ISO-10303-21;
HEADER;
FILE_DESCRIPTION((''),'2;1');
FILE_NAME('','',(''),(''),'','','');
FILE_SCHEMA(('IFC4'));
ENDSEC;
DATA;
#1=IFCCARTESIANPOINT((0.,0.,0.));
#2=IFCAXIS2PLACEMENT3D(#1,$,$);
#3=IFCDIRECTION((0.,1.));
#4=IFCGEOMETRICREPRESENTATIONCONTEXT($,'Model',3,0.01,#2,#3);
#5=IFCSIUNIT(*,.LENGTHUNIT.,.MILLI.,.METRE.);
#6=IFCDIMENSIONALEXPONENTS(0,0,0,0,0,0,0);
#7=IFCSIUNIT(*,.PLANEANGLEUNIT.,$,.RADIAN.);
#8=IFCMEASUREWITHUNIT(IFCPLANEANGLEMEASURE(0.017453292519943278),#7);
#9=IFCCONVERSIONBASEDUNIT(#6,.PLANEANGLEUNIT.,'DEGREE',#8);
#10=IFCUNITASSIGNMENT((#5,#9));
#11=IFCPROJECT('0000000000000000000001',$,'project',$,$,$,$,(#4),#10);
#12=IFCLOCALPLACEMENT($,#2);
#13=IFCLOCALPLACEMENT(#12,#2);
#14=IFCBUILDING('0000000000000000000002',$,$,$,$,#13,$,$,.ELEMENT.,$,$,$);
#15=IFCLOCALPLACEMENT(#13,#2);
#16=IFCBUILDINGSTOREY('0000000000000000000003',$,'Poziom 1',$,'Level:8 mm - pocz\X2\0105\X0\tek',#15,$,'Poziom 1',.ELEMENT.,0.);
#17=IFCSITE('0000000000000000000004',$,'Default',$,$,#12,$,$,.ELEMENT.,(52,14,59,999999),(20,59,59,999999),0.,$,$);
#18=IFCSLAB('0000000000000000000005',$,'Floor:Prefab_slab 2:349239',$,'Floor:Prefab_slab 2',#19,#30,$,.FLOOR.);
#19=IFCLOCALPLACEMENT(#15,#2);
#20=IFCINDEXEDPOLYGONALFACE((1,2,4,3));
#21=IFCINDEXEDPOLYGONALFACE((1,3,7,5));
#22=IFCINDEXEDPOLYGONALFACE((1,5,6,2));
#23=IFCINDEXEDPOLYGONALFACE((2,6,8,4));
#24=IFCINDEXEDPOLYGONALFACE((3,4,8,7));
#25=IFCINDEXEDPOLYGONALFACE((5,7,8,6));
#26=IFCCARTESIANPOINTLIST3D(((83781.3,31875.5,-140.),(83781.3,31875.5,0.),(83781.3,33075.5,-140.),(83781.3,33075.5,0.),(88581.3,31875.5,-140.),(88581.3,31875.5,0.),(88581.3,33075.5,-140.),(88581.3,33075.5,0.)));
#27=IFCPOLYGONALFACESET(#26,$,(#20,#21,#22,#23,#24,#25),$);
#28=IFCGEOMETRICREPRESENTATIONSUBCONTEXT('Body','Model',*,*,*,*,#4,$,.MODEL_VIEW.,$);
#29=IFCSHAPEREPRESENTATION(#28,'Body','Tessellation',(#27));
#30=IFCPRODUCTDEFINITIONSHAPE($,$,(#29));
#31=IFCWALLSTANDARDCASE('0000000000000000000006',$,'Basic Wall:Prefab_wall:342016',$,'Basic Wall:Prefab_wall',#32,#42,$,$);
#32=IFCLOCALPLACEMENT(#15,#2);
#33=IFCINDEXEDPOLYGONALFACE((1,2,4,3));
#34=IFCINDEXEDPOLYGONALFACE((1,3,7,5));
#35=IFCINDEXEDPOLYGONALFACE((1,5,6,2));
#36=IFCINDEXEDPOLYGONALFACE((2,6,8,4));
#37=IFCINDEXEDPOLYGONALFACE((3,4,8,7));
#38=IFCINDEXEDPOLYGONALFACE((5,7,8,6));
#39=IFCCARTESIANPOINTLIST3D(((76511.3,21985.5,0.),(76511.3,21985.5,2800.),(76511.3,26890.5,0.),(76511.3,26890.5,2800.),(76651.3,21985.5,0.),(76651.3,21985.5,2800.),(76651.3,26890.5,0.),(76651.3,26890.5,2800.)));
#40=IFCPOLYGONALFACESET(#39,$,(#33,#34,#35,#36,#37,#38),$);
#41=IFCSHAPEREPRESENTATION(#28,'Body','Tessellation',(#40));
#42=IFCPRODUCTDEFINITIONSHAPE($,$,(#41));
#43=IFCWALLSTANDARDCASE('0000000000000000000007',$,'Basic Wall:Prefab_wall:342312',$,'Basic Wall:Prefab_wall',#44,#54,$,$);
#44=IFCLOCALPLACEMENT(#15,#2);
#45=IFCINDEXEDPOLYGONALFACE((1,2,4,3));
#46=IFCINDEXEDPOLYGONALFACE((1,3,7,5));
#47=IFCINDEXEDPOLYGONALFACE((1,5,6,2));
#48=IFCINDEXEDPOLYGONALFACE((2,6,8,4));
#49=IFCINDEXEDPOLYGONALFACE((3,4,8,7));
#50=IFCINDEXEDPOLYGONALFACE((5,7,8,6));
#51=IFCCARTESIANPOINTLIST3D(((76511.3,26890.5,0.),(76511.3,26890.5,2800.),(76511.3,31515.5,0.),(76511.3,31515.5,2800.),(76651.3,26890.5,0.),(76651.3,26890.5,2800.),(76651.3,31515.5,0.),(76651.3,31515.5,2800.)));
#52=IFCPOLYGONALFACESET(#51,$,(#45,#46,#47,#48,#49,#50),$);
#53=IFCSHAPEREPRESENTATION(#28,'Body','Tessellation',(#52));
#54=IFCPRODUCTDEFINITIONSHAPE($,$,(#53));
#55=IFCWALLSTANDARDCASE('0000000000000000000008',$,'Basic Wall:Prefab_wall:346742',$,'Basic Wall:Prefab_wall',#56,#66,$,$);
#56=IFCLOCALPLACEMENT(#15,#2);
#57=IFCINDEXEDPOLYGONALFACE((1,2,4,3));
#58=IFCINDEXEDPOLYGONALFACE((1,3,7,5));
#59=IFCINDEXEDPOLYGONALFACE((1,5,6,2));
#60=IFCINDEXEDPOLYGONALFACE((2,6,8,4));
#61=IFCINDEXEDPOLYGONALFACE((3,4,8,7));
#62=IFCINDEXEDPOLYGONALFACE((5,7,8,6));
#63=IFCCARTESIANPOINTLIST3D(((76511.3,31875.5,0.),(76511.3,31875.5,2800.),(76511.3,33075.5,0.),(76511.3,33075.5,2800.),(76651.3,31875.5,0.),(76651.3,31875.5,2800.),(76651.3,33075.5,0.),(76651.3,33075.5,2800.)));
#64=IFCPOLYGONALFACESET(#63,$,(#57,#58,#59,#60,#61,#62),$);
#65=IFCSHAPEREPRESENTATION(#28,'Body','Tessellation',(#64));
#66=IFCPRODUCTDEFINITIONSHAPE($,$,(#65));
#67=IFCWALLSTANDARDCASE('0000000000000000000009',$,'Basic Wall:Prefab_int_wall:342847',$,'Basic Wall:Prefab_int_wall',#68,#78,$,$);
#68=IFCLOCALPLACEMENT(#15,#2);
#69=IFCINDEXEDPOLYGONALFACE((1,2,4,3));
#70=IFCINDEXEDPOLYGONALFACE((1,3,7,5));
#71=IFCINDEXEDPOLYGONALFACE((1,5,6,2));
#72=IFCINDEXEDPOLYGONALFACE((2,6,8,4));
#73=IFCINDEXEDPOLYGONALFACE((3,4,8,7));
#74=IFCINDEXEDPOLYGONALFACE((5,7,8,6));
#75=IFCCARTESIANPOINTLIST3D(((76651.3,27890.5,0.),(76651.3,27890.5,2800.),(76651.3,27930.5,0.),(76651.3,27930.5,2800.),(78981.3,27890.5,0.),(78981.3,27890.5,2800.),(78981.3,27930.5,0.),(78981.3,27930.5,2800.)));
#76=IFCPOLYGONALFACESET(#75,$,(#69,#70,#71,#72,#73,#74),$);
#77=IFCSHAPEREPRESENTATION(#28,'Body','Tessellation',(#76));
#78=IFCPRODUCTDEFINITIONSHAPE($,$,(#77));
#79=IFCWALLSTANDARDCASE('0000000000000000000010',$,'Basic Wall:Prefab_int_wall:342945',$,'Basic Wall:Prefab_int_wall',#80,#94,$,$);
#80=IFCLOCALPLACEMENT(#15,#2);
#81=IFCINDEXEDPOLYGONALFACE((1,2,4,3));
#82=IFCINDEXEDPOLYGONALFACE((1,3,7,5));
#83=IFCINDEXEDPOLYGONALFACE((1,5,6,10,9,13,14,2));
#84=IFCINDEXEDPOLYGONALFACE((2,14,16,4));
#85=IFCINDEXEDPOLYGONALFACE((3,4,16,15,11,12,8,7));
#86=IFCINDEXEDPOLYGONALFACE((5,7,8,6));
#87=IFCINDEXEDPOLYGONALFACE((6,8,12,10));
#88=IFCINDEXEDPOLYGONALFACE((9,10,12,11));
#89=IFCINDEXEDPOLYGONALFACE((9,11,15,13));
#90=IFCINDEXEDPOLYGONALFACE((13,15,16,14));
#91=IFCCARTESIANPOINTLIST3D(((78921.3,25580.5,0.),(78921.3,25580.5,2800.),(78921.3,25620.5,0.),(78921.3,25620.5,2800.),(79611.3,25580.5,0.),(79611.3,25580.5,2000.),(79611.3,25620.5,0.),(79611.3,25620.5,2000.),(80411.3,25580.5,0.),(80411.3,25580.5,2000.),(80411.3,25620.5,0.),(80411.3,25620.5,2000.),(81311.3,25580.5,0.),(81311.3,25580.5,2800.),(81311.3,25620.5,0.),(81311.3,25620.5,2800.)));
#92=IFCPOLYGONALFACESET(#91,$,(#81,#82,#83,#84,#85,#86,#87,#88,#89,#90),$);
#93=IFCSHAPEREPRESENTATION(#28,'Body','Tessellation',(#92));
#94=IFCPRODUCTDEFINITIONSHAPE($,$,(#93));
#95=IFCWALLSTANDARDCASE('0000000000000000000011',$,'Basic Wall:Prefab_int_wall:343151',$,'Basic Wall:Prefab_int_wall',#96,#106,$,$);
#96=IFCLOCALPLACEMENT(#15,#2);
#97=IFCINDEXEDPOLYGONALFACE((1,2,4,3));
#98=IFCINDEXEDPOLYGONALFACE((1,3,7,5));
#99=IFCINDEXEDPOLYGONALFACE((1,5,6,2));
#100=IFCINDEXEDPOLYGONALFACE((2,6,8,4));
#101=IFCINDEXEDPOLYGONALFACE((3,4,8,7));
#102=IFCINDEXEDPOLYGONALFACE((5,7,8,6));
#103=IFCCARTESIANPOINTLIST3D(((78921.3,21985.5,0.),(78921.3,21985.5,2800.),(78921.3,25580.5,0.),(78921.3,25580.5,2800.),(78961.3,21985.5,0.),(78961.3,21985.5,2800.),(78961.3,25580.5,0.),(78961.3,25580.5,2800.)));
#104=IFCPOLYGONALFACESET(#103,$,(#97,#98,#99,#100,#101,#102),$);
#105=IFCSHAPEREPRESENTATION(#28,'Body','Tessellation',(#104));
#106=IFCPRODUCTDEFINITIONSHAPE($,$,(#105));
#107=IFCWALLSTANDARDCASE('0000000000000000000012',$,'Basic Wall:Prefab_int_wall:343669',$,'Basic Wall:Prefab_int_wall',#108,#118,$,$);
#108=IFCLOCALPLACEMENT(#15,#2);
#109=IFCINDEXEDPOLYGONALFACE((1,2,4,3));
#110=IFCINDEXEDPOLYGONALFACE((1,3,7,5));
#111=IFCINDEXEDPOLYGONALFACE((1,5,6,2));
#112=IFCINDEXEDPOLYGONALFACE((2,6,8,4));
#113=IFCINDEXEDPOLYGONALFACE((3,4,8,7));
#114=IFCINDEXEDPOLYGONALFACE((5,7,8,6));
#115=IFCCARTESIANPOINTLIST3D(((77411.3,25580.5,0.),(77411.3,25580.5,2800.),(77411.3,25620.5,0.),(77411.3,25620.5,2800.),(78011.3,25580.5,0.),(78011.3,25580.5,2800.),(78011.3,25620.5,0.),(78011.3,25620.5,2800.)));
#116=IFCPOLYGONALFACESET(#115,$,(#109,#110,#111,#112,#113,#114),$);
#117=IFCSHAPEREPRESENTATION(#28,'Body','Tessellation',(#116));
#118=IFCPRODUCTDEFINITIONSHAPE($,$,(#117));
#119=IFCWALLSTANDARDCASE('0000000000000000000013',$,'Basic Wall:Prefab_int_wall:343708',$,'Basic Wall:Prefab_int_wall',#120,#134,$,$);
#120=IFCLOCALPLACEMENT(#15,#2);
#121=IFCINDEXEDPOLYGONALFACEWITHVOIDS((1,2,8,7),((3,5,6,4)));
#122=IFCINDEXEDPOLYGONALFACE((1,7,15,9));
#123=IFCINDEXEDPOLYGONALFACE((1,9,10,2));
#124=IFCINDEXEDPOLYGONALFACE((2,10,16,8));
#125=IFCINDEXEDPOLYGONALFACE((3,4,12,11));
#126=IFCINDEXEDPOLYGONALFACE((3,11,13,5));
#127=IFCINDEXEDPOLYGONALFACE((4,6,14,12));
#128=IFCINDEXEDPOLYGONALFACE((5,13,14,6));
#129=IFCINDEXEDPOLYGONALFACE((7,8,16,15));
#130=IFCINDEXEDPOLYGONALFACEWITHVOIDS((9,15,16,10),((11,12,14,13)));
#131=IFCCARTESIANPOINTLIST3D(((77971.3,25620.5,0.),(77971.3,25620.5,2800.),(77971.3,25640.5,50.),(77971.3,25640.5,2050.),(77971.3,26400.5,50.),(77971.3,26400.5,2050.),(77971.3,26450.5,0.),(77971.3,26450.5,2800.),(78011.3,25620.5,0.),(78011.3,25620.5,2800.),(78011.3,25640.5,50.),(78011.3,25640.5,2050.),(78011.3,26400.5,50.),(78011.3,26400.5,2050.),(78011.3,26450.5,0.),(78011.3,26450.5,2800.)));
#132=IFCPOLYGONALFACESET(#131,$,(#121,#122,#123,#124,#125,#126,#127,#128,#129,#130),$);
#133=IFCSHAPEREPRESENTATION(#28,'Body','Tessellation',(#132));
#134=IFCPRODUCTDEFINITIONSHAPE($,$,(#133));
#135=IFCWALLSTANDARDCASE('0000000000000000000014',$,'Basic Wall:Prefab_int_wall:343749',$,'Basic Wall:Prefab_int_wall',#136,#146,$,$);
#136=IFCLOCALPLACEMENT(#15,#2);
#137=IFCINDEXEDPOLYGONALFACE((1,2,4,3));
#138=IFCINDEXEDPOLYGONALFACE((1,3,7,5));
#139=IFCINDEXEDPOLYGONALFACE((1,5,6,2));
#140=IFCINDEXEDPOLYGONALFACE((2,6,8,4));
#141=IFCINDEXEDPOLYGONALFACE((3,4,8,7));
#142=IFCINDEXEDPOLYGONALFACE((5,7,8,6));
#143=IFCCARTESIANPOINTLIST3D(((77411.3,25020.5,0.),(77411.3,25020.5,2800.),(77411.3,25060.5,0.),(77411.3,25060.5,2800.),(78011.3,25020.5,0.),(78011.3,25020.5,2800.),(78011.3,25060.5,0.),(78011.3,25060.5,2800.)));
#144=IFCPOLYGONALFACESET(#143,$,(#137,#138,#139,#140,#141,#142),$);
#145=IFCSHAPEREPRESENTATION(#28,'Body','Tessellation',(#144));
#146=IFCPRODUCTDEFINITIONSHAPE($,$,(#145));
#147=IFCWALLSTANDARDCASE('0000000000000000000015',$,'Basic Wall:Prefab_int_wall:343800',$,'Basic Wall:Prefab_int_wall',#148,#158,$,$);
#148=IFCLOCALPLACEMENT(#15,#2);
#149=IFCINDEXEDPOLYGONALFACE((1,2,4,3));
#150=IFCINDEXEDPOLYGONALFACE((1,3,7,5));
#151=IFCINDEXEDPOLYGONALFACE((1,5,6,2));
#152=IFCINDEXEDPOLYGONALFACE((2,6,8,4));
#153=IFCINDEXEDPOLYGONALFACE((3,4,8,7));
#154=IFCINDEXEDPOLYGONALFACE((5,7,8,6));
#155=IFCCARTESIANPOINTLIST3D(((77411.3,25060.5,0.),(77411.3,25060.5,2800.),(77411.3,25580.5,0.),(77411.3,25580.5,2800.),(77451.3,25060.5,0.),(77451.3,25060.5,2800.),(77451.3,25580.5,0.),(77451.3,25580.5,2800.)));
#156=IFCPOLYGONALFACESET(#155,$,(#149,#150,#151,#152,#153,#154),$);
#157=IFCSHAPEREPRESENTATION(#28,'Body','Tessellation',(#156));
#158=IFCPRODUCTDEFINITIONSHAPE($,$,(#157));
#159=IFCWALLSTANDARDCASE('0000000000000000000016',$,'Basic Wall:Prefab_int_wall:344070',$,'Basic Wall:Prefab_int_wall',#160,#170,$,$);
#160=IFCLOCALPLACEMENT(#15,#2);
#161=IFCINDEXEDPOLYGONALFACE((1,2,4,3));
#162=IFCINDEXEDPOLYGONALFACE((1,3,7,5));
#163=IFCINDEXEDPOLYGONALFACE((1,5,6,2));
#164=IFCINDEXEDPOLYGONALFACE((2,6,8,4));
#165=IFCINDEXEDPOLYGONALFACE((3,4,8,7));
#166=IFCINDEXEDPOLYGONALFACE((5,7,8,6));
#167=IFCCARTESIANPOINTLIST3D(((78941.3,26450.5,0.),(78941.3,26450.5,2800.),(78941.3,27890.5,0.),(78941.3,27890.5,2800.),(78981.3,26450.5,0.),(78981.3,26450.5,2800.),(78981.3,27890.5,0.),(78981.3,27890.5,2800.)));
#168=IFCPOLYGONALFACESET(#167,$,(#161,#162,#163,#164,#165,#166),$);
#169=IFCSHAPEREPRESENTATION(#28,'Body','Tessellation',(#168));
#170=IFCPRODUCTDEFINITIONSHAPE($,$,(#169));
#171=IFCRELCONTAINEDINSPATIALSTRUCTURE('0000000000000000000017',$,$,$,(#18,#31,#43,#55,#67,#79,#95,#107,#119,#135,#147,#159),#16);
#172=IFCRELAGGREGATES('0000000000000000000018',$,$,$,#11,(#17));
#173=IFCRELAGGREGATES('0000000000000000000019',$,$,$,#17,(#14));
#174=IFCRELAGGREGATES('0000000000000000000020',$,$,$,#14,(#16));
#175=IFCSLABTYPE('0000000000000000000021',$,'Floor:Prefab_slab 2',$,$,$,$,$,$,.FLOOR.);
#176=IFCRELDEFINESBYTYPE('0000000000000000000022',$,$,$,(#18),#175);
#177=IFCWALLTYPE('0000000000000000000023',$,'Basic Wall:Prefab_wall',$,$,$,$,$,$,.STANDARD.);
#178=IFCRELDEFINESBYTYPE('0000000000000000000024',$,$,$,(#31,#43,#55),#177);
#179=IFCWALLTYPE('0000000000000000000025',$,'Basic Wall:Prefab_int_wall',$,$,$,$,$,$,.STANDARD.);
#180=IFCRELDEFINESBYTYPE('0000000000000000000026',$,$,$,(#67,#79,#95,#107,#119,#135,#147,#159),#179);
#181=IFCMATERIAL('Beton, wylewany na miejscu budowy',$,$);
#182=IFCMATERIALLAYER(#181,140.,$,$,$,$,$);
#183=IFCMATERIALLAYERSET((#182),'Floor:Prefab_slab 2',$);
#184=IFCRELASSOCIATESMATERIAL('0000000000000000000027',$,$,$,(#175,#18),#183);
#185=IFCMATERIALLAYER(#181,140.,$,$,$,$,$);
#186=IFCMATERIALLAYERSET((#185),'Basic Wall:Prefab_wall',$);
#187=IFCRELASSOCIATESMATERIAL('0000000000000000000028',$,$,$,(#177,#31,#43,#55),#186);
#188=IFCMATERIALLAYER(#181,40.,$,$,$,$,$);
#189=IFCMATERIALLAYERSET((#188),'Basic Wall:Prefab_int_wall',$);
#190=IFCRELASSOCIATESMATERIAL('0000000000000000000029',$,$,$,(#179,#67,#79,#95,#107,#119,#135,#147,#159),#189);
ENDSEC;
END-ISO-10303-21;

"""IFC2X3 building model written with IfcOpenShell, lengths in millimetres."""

from ifc_helpers import new_model, entity, si_unit, converted_unit, direction, frame, frame_2d, origin, origin_2d_with_axis, place, context, subcontext, project, spatial, rectangle, extrude, material, layer, layer_set, layer_usage, type_object, element, save


model = new_model("IFC2X3")

# Units and contexts
model_context = context("Model", 3, precision=0.01, world=origin(), true_north=direction((0.0, 1.0)))
body_context = subcontext(model_context, "Body", "Model", "MODEL_VIEW")
ifc_project = project(units=[si_unit("LENGTHUNIT", "METRE", prefix="MILLI"), converted_unit("PLANEANGLEUNIT", "DEGREE", entity("IfcPlaneAngleMeasure", 0.017453292519943278), si_unit("PLANEANGLEUNIT", "RADIAN"), dimensions=[0, 0, 0, 0, 0, 0, 0])], contexts=[model_context])

# Site, building, storey
site_placement = place(None, origin())
site = spatial("IfcSite", under=ifc_project, at=site_placement, Name="Default", CompositionType="ELEMENT", RefLatitude=(52, 14, 59, 999999), RefLongitude=(20, 59, 59, 999999), RefElevation=0.0)
building_placement = place(site_placement, origin())
building = spatial("IfcBuilding", under=site, at=building_placement, CompositionType="ELEMENT")
storey_placement = place(building_placement, origin())
storey = spatial("IfcBuildingStorey", under=building, at=storey_placement, Name="Poziom 1", ObjectType="Level:8 mm - początek", LongName="Poziom 1", CompositionType="ELEMENT", Elevation=0.0)

# Slab
ifc_material_1 = material(Name="Beton, wylewany na miejscu budowy")
ifc_layer_1 = layer(ifc_material_1, 140.0)
ifc_layer_set_1 = layer_set([ifc_layer_1], Name="Floor:Prefab_slab 2")
slab_type_1 = type_object("IfcSlabType", Name="Floor:Prefab_slab 2", PredefinedType="FLOOR", material=ifc_layer_set_1)
ifc_layer_usage_1 = layer_usage(ifc_layer_set_1, "AXIS3", "POSITIVE", 0.0)
slab_1_placement = place(storey_placement, origin())
element("IfcSlab", 1, at=slab_1_placement, inside=storey, type_object=slab_type_1, material=ifc_layer_usage_1, Name="Floor:Prefab_slab 2:349239", ObjectType="Floor:Prefab_slab 2", PredefinedType="FLOOR", context=body_context, shape_type="SweptSolid", body=[
    extrude(rectangle(XDim=1200.0, YDim=4800.0, at=frame_2d((0.0, 0.0), x_axis=(1.0, 0.0))), frame((86181.3, 32475.5, 0.0), z_axis=(0.0, 0.0, -1.0), x_axis=(0.0, 1.0, 0.0)), (0.0, 0.0, 1.0), 140.0),
])

# Walls
ifc_layer_2 = layer(ifc_material_1, 140.0)
ifc_layer_set_2 = layer_set([ifc_layer_2], Name="Basic Wall:Prefab_wall")
ifc_layer_usage_2 = layer_usage(ifc_layer_set_2, "AXIS2", "NEGATIVE", 70.0)
wall_type_1 = type_object("IfcWallType", Name="Basic Wall:Prefab_wall", PredefinedType="STANDARD", material=ifc_layer_set_2)
wall_1_placement = place(storey_placement, frame((76581.3, 21985.5, 0.0), z_axis=(0.0, 0.0, 1.0), x_axis=(0.0, 1.0, 0.0)))
element("IfcWallStandardCase", 2, at=wall_1_placement, inside=storey, type_object=wall_type_1, material=ifc_layer_usage_2, Name="Basic Wall:Prefab_wall:342016", ObjectType="Basic Wall:Prefab_wall", context=body_context, shape_type="SweptSolid", body=[
    extrude(rectangle(XDim=4905.0, YDim=140.0, at=frame_2d((2452.5, 0.0), x_axis=(-1.0, 0.0))), origin(), (0.0, 0.0, 1.0), 2800.0),
])
ifc_layer_usage_3 = layer_usage(ifc_layer_set_2, "AXIS2", "NEGATIVE", 70.0)
wall_2_placement = place(storey_placement, frame((76581.3, 31515.5, 0.0), z_axis=(0.0, 0.0, 1.0), x_axis=(0.0, -1.0, 0.0)))
element("IfcWallStandardCase", 3, at=wall_2_placement, inside=storey, type_object=wall_type_1, material=ifc_layer_usage_3, Name="Basic Wall:Prefab_wall:342312", ObjectType="Basic Wall:Prefab_wall", context=body_context, shape_type="SweptSolid", body=[
    extrude(rectangle(XDim=4625.0, YDim=140.0, at=frame_2d((2312.5, 0.0), x_axis=(-1.0, 0.0))), origin(), (0.0, 0.0, 1.0), 2800.0),
])
ifc_layer_usage_4 = layer_usage(ifc_layer_set_2, "AXIS2", "NEGATIVE", 70.0)
wall_3_placement = place(storey_placement, frame((76581.3, 33075.5, 0.0), z_axis=(0.0, 0.0, 1.0), x_axis=(0.0, -1.0, 0.0)))
element("IfcWallStandardCase", 4, at=wall_3_placement, inside=storey, type_object=wall_type_1, material=ifc_layer_usage_4, Name="Basic Wall:Prefab_wall:346742", ObjectType="Basic Wall:Prefab_wall", context=body_context, shape_type="SweptSolid", body=[
    extrude(rectangle(XDim=1200.0, YDim=140.0, at=frame_2d((600.0, 0.0), x_axis=(-1.0, 0.0))), origin(), (0.0, 0.0, 1.0), 2800.0),
])
ifc_layer_3 = layer(ifc_material_1, 40.0)
ifc_layer_set_3 = layer_set([ifc_layer_3], Name="Basic Wall:Prefab_int_wall")
ifc_layer_usage_5 = layer_usage(ifc_layer_set_3, "AXIS2", "NEGATIVE", 20.0)
wall_type_2 = type_object("IfcWallType", Name="Basic Wall:Prefab_int_wall", PredefinedType="STANDARD", material=ifc_layer_set_3)
wall_4_placement = place(storey_placement, frame((76651.3, 27910.5, 0.0)))
element("IfcWallStandardCase", 5, at=wall_4_placement, inside=storey, type_object=wall_type_2, material=ifc_layer_usage_5, Name="Basic Wall:Prefab_int_wall:342847", ObjectType="Basic Wall:Prefab_int_wall", context=body_context, shape_type="SweptSolid", body=[
    extrude(rectangle(XDim=2330.0, YDim=40.0, at=frame_2d((1165.0, 0.0), x_axis=(-1.0, 0.0))), origin(), (0.0, 0.0, 1.0), 2800.0),
])

# Wall, opening
ifc_layer_usage_6 = layer_usage(ifc_layer_set_3, "AXIS2", "NEGATIVE", 20.0)
wall_5_placement = place(storey_placement, frame((78921.3, 25600.5, 0.0)))
wall_5 = element("IfcWallStandardCase", 6, at=wall_5_placement, inside=storey, type_object=wall_type_2, material=ifc_layer_usage_6, Name="Basic Wall:Prefab_int_wall:342945", ObjectType="Basic Wall:Prefab_int_wall", context=body_context, shape_type="SweptSolid", body=[
    extrude(rectangle(XDim=2390.0, YDim=40.0, at=frame_2d((1195.0, 0.0), x_axis=(-1.0, 0.0))), origin(), (0.0, 0.0, 1.0), 2800.0),
])
opening_1_placement = place(wall_5_placement, origin())
element("IfcOpeningElement", 7, at=opening_1_placement, cuts=wall_5, ObjectType="Opening", context=body_context, shape_type="SweptSolid", body=[
    extrude(rectangle(XDim=2000.0, YDim=800.0, at=frame_2d((0.0, 0.0), x_axis=(0.0, 1.0))), frame((1090.0, 20.0, 1000.0), z_axis=(0.0, -1.0, 0.0), x_axis=(1.0, 0.0, 0.0)), (0.0, 0.0, 1.0), 40.0),
])

# Walls
ifc_layer_usage_7 = layer_usage(ifc_layer_set_3, "AXIS2", "NEGATIVE", 20.0)
wall_6_placement = place(storey_placement, frame((78941.3, 25580.5, 0.0), z_axis=(0.0, 0.0, 1.0), x_axis=(0.0, -1.0, 0.0)))
element("IfcWallStandardCase", 8, at=wall_6_placement, inside=storey, type_object=wall_type_2, material=ifc_layer_usage_7, Name="Basic Wall:Prefab_int_wall:343151", ObjectType="Basic Wall:Prefab_int_wall", context=body_context, shape_type="SweptSolid", body=[
    extrude(rectangle(XDim=3595.0, YDim=40.0, at=frame_2d((1797.5, 0.0), x_axis=(-1.0, 0.0))), origin(), (0.0, 0.0, 1.0), 2800.0),
])
ifc_layer_usage_8 = layer_usage(ifc_layer_set_3, "AXIS2", "NEGATIVE", 20.0)
wall_7_placement = place(storey_placement, frame((77411.3, 25600.5, 0.0)))
element("IfcWallStandardCase", 9, at=wall_7_placement, inside=storey, type_object=wall_type_2, material=ifc_layer_usage_8, Name="Basic Wall:Prefab_int_wall:343669", ObjectType="Basic Wall:Prefab_int_wall", context=body_context, shape_type="SweptSolid", body=[
    extrude(rectangle(XDim=600.0, YDim=40.0, at=frame_2d((300.0, 0.0), x_axis=(-1.0, 0.0))), origin(), (0.0, 0.0, 1.0), 2800.0),
])

# Wall, opening
ifc_layer_usage_9 = layer_usage(ifc_layer_set_3, "AXIS2", "NEGATIVE", 20.0)
wall_8_placement = place(storey_placement, frame((77991.3, 26450.5, 0.0), z_axis=(0.0, 0.0, 1.0), x_axis=(0.0, -1.0, 0.0)))
wall_8 = element("IfcWallStandardCase", 10, at=wall_8_placement, inside=storey, type_object=wall_type_2, material=ifc_layer_usage_9, Name="Basic Wall:Prefab_int_wall:343708", ObjectType="Basic Wall:Prefab_int_wall", context=body_context, shape_type="SweptSolid", body=[
    extrude(rectangle(XDim=830.0, YDim=40.0, at=frame_2d((415.0, 0.0), x_axis=(-1.0, 0.0))), origin(), (0.0, 0.0, 1.0), 2800.0),
])
opening_2_placement = place(wall_8_placement, origin())
element("IfcOpeningElement", 11, at=opening_2_placement, cuts=wall_8, ObjectType="Opening", context=body_context, shape_type="SweptSolid", body=[
    extrude(rectangle(XDim=2000.0, YDim=760.0, at=origin_2d_with_axis()), frame((430.0, 20.0, 1050.0), z_axis=(0.0, -1.0, 0.0), x_axis=(0.0, 0.0, 1.0)), (0.0, 0.0, 1.0), 40.0),
])

# Walls
ifc_layer_usage_10 = layer_usage(ifc_layer_set_3, "AXIS2", "NEGATIVE", 20.0)
wall_9_placement = place(storey_placement, frame((78011.3, 25040.5, 0.0), z_axis=(0.0, 0.0, 1.0), x_axis=(-1.0, 0.0, 0.0)))
element("IfcWallStandardCase", 12, at=wall_9_placement, inside=storey, type_object=wall_type_2, material=ifc_layer_usage_10, Name="Basic Wall:Prefab_int_wall:343749", ObjectType="Basic Wall:Prefab_int_wall", context=body_context, shape_type="SweptSolid", body=[
    extrude(rectangle(XDim=600.0, YDim=40.0, at=frame_2d((300.0, 0.0), x_axis=(-1.0, 0.0))), origin(), (0.0, 0.0, 1.0), 2800.0),
])
ifc_layer_usage_11 = layer_usage(ifc_layer_set_3, "AXIS2", "NEGATIVE", 20.0)
wall_10_placement = place(storey_placement, frame((77431.3, 25060.5, 0.0), z_axis=(0.0, 0.0, 1.0), x_axis=(0.0, 1.0, 0.0)))
element("IfcWallStandardCase", 13, at=wall_10_placement, inside=storey, type_object=wall_type_2, material=ifc_layer_usage_11, Name="Basic Wall:Prefab_int_wall:343800", ObjectType="Basic Wall:Prefab_int_wall", context=body_context, shape_type="SweptSolid", body=[
    extrude(rectangle(XDim=520.0, YDim=40.0, at=frame_2d((260.0, 0.0), x_axis=(-1.0, 0.0))), origin(), (0.0, 0.0, 1.0), 2800.0),
])
ifc_layer_usage_12 = layer_usage(ifc_layer_set_3, "AXIS2", "NEGATIVE", 20.0)
wall_11_placement = place(storey_placement, frame((78961.3, 27890.5, 0.0), z_axis=(0.0, 0.0, 1.0), x_axis=(0.0, -1.0, 0.0)))
element("IfcWallStandardCase", 14, at=wall_11_placement, inside=storey, type_object=wall_type_2, material=ifc_layer_usage_12, Name="Basic Wall:Prefab_int_wall:344070", ObjectType="Basic Wall:Prefab_int_wall", context=body_context, shape_type="SweptSolid", body=[
    extrude(rectangle(XDim=1440.0, YDim=40.0, at=frame_2d((720.0, 0.0), x_axis=(-1.0, 0.0))), origin(), (0.0, 0.0, 1.0), 2800.0),
])

save(model, "model.ifc")
